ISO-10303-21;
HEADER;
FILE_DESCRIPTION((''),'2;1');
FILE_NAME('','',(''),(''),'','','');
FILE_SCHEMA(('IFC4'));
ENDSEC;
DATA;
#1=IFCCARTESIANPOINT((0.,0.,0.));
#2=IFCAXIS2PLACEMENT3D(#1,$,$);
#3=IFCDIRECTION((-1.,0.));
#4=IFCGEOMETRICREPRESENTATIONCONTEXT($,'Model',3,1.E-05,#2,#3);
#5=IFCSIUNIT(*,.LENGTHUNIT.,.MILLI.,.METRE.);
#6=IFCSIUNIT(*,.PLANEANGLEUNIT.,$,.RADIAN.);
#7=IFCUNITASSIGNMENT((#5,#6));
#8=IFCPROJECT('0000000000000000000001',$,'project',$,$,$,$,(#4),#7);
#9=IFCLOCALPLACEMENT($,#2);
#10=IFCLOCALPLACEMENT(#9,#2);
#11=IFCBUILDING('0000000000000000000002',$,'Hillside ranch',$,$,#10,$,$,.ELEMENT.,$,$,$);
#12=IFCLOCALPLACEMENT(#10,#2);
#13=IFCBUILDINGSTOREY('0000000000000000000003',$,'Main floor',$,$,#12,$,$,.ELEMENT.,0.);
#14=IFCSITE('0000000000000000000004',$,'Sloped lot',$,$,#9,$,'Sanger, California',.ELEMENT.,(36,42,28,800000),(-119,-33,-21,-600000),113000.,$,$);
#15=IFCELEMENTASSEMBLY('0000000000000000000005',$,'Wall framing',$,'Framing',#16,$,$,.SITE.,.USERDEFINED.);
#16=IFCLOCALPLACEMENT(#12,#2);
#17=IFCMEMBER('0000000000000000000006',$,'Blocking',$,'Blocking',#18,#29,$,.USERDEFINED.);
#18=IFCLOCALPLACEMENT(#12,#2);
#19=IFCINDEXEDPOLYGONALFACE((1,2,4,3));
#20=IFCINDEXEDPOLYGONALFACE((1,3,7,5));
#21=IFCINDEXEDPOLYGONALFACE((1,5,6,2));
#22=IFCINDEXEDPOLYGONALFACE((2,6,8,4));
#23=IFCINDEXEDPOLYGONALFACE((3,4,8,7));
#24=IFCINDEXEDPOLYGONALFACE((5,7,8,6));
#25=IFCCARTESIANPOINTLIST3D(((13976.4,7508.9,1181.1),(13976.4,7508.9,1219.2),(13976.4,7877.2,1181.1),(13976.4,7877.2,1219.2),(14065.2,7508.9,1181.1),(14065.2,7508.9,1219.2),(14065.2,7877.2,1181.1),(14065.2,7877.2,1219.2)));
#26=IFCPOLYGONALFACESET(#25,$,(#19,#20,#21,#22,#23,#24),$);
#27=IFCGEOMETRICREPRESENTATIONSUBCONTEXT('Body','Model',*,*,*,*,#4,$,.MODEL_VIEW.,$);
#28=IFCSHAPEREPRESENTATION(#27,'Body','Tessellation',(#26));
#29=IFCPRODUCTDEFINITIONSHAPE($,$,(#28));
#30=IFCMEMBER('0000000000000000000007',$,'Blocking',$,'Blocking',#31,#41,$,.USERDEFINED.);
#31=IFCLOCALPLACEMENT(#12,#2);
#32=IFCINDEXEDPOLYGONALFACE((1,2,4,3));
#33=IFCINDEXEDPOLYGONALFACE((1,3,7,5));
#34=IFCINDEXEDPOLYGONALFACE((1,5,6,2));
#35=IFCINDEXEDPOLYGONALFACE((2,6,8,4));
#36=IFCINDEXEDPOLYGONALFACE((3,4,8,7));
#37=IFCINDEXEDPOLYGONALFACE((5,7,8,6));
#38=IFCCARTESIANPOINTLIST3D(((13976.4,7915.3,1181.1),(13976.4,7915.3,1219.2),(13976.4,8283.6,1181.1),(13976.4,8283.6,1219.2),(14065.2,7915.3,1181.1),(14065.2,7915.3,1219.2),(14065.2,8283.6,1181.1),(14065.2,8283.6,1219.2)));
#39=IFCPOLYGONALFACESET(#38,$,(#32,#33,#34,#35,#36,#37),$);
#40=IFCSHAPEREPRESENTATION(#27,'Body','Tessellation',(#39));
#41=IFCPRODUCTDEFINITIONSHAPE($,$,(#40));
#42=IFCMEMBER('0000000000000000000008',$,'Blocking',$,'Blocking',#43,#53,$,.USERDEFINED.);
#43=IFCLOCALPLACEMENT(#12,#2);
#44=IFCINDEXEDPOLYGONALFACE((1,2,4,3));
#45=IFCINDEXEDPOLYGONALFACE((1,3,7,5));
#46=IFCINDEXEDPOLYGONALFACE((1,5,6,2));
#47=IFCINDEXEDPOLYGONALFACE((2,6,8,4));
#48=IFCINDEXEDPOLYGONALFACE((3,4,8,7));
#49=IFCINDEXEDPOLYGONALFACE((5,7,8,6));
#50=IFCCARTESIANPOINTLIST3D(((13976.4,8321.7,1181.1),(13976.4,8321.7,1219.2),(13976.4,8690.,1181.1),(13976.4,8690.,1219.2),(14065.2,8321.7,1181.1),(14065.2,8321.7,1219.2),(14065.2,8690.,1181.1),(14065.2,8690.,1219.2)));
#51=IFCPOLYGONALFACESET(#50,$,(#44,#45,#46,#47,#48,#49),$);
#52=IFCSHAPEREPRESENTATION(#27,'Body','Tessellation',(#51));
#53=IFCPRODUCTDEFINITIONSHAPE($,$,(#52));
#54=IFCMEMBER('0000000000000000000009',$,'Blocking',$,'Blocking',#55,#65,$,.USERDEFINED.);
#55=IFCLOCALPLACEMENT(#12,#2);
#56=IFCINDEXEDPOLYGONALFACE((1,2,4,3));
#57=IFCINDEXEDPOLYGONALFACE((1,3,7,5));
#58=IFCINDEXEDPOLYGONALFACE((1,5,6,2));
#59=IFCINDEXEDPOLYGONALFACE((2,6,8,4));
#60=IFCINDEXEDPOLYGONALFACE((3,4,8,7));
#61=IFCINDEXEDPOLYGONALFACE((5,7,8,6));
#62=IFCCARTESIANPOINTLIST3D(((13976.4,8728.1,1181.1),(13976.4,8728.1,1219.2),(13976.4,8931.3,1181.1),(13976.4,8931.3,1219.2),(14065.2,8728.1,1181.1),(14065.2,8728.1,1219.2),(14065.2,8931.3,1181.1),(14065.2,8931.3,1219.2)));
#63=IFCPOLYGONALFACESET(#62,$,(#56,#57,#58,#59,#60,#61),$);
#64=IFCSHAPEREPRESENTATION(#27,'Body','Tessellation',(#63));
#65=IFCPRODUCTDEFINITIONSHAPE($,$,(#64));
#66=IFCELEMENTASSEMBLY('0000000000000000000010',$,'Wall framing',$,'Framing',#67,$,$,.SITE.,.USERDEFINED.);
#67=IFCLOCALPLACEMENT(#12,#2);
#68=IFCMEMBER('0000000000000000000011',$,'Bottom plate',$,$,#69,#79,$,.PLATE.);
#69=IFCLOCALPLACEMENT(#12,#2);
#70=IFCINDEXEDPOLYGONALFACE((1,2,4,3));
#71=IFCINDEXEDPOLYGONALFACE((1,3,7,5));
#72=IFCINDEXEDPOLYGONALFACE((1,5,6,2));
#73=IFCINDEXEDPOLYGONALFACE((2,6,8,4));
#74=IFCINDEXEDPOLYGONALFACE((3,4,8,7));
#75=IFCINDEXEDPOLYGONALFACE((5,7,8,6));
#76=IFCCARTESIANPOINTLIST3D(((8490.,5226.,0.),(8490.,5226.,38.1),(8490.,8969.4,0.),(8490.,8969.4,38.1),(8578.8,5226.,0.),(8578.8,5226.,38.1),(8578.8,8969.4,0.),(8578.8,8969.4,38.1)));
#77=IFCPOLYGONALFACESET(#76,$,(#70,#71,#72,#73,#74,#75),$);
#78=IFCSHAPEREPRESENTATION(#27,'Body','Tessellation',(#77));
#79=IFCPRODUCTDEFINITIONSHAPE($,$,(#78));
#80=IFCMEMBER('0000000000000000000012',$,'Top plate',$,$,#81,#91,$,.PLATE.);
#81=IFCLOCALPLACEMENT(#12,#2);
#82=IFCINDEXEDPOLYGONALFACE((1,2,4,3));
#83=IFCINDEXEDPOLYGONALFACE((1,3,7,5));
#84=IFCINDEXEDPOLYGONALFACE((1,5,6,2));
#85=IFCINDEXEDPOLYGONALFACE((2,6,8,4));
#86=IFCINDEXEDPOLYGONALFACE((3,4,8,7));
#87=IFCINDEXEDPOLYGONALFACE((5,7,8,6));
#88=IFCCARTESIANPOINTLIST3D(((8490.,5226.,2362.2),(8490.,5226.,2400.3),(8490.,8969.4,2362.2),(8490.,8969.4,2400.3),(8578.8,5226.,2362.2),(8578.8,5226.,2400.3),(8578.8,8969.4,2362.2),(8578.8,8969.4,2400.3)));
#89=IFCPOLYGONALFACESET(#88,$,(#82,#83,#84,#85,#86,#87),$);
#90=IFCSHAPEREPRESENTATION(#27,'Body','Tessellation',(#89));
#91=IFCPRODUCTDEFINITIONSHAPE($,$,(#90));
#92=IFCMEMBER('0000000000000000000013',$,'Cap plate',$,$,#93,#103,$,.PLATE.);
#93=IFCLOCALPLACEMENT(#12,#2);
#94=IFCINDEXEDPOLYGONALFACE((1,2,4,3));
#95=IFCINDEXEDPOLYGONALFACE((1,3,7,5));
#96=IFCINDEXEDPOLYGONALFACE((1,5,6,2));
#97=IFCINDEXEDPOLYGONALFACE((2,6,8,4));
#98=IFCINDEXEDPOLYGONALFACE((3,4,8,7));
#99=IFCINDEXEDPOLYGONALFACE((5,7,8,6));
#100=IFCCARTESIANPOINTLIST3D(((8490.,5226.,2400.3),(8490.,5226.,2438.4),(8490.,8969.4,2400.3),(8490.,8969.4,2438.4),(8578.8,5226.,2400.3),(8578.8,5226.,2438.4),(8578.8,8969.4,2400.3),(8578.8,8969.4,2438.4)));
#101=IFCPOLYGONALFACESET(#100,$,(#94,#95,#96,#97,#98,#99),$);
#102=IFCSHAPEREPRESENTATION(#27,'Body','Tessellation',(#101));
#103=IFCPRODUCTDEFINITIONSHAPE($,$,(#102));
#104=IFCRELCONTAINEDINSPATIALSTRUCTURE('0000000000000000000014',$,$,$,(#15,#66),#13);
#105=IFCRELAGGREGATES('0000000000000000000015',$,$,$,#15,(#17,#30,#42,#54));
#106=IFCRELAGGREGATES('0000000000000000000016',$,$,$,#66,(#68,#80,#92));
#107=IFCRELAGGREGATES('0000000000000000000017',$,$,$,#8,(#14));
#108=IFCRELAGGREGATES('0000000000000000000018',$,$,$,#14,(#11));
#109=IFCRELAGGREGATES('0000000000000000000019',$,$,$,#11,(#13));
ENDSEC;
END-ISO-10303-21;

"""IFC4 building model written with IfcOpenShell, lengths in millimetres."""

from ifc_helpers import new_model, si_unit, direction, frame, origin, origin_with_axes, place, context, subcontext, project, spatial, polyline, outline, extrude, element, aggregate, save


model = new_model("IFC4")

# Units and contexts
model_context = context("Model", 3, precision=1e-05, world=origin(), true_north=direction((-1.0, 0.0)))
body_context = subcontext(model_context, "Body", "Model", "MODEL_VIEW")
ifc_project = project(units=[si_unit("LENGTHUNIT", "METRE", prefix="MILLI"), si_unit("PLANEANGLEUNIT", "RADIAN")], contexts=[model_context])

# Site, building, storey
site_placement = place(None, origin())
site = spatial("IfcSite", under=ifc_project, at=site_placement, Name="Sloped lot", LongName="Sanger, California", CompositionType="ELEMENT", RefLatitude=(36, 42, 28, 800000), RefLongitude=(-119, -33, -21, -600000), RefElevation=113000.0)
building_placement = place(site_placement, origin())
building = spatial("IfcBuilding", under=site, at=building_placement, Name="Hillside ranch", CompositionType="ELEMENT")
storey_placement = place(building_placement, origin())
storey = spatial("IfcBuildingStorey", under=building, at=storey_placement, Name="Main floor", CompositionType="ELEMENT", Elevation=0.0)

# Element assemblies, members
assembly_1_placement = place(storey_placement, origin_with_axes())
assembly_1 = element("IfcElementAssembly", 1, at=assembly_1_placement, inside=storey, Name="Wall framing", ObjectType="Framing", AssemblyPlace="SITE", PredefinedType="USERDEFINED")
member_1_placement = place(storey_placement, origin_with_axes())
member_1 = element("IfcMember", 2, at=member_1_placement, Name="Blocking", ObjectType="Blocking", PredefinedType="USERDEFINED", context=body_context, shape_type="SweptSolid", body=[
    extrude(outline(polyline([(0.0, 0.0), (368.3, 0.0), (368.3, 88.9), (0.0, 88.9), (0.0, 0.0)])), frame((14065.2, 7508.9, 1181.1), z_axis=(0.0, 0.0, 1.0), x_axis=(0.0, 1.0, 0.0)), (0.0, 0.0, 1.0), 38.1),
])
member_2_placement = place(storey_placement, origin_with_axes())
member_2 = element("IfcMember", 3, at=member_2_placement, Name="Blocking", ObjectType="Blocking", PredefinedType="USERDEFINED", context=body_context, shape_type="SweptSolid", body=[
    extrude(outline(polyline([(0.0, 0.0), (368.3, 0.0), (368.3, 88.9), (0.0, 88.9), (0.0, 0.0)])), frame((14065.2, 7915.3, 1181.1), z_axis=(0.0, 0.0, 1.0), x_axis=(0.0, 1.0, 0.0)), (0.0, 0.0, 1.0), 38.1),
])
member_3_placement = place(storey_placement, origin_with_axes())
member_3 = element("IfcMember", 4, at=member_3_placement, Name="Blocking", ObjectType="Blocking", PredefinedType="USERDEFINED", context=body_context, shape_type="SweptSolid", body=[
    extrude(outline(polyline([(0.0, 0.0), (368.3, 0.0), (368.3, 88.9), (0.0, 88.9), (0.0, 0.0)])), frame((14065.2, 8321.7, 1181.1), z_axis=(0.0, 0.0, 1.0), x_axis=(0.0, 1.0, 0.0)), (0.0, 0.0, 1.0), 38.1),
])
member_4_placement = place(storey_placement, origin_with_axes())
member_4 = element("IfcMember", 5, at=member_4_placement, Name="Blocking", ObjectType="Blocking", PredefinedType="USERDEFINED", context=body_context, shape_type="SweptSolid", body=[
    extrude(outline(polyline([(0.0, 0.0), (203.2, 0.0), (203.2, 88.9), (0.0, 88.9), (0.0, 0.0)])), frame((14065.2, 8728.1, 1181.1), z_axis=(0.0, 0.0, 1.0), x_axis=(0.0, 1.0, 0.0)), (0.0, 0.0, 1.0), 38.1),
])
aggregate(assembly_1, [member_1, member_2, member_3, member_4])
assembly_2_placement = place(storey_placement, origin_with_axes())
assembly_2 = element("IfcElementAssembly", 6, at=assembly_2_placement, inside=storey, Name="Wall framing", ObjectType="Framing", AssemblyPlace="SITE", PredefinedType="USERDEFINED")
member_5_placement = place(storey_placement, origin_with_axes())
member_5 = element("IfcMember", 7, at=member_5_placement, Name="Bottom plate", PredefinedType="PLATE", context=body_context, shape_type="SweptSolid", body=[
    extrude(outline(polyline([(0.0, 0.0), (3743.3, 0.0), (3743.3, 88.9), (0.0, 88.9), (0.0, 0.0)])), frame((8578.9, 5226.1, 0.0), z_axis=(0.0, 0.0, 1.0), x_axis=(0.0, 1.0, 0.0)), (0.0, 0.0, 1.0), 38.1),
])
member_6_placement = place(storey_placement, origin_with_axes())
member_6 = element("IfcMember", 8, at=member_6_placement, Name="Top plate", PredefinedType="PLATE", context=body_context, shape_type="SweptSolid", body=[
    extrude(outline(polyline([(0.0, 0.0), (3743.3, 0.0), (3743.3, 88.9), (0.0, 88.9), (0.0, 0.0)])), frame((8578.9, 5226.1, 2362.2), z_axis=(0.0, 0.0, 1.0), x_axis=(0.0, 1.0, 0.0)), (0.0, 0.0, 1.0), 38.1),
])
member_7_placement = place(storey_placement, origin_with_axes())
member_7 = element("IfcMember", 9, at=member_7_placement, Name="Cap plate", PredefinedType="PLATE", context=body_context, shape_type="SweptSolid", body=[
    extrude(outline(polyline([(0.0, 0.0), (3743.3, 0.0), (3743.3, 88.9), (0.0, 88.9), (0.0, 0.0)])), frame((8578.9, 5226.1, 2400.3), z_axis=(0.0, 0.0, 1.0), x_axis=(0.0, 1.0, 0.0)), (0.0, 0.0, 1.0), 38.1),
])
aggregate(assembly_2, [member_5, member_6, member_7])

save(model, "model.ifc")
